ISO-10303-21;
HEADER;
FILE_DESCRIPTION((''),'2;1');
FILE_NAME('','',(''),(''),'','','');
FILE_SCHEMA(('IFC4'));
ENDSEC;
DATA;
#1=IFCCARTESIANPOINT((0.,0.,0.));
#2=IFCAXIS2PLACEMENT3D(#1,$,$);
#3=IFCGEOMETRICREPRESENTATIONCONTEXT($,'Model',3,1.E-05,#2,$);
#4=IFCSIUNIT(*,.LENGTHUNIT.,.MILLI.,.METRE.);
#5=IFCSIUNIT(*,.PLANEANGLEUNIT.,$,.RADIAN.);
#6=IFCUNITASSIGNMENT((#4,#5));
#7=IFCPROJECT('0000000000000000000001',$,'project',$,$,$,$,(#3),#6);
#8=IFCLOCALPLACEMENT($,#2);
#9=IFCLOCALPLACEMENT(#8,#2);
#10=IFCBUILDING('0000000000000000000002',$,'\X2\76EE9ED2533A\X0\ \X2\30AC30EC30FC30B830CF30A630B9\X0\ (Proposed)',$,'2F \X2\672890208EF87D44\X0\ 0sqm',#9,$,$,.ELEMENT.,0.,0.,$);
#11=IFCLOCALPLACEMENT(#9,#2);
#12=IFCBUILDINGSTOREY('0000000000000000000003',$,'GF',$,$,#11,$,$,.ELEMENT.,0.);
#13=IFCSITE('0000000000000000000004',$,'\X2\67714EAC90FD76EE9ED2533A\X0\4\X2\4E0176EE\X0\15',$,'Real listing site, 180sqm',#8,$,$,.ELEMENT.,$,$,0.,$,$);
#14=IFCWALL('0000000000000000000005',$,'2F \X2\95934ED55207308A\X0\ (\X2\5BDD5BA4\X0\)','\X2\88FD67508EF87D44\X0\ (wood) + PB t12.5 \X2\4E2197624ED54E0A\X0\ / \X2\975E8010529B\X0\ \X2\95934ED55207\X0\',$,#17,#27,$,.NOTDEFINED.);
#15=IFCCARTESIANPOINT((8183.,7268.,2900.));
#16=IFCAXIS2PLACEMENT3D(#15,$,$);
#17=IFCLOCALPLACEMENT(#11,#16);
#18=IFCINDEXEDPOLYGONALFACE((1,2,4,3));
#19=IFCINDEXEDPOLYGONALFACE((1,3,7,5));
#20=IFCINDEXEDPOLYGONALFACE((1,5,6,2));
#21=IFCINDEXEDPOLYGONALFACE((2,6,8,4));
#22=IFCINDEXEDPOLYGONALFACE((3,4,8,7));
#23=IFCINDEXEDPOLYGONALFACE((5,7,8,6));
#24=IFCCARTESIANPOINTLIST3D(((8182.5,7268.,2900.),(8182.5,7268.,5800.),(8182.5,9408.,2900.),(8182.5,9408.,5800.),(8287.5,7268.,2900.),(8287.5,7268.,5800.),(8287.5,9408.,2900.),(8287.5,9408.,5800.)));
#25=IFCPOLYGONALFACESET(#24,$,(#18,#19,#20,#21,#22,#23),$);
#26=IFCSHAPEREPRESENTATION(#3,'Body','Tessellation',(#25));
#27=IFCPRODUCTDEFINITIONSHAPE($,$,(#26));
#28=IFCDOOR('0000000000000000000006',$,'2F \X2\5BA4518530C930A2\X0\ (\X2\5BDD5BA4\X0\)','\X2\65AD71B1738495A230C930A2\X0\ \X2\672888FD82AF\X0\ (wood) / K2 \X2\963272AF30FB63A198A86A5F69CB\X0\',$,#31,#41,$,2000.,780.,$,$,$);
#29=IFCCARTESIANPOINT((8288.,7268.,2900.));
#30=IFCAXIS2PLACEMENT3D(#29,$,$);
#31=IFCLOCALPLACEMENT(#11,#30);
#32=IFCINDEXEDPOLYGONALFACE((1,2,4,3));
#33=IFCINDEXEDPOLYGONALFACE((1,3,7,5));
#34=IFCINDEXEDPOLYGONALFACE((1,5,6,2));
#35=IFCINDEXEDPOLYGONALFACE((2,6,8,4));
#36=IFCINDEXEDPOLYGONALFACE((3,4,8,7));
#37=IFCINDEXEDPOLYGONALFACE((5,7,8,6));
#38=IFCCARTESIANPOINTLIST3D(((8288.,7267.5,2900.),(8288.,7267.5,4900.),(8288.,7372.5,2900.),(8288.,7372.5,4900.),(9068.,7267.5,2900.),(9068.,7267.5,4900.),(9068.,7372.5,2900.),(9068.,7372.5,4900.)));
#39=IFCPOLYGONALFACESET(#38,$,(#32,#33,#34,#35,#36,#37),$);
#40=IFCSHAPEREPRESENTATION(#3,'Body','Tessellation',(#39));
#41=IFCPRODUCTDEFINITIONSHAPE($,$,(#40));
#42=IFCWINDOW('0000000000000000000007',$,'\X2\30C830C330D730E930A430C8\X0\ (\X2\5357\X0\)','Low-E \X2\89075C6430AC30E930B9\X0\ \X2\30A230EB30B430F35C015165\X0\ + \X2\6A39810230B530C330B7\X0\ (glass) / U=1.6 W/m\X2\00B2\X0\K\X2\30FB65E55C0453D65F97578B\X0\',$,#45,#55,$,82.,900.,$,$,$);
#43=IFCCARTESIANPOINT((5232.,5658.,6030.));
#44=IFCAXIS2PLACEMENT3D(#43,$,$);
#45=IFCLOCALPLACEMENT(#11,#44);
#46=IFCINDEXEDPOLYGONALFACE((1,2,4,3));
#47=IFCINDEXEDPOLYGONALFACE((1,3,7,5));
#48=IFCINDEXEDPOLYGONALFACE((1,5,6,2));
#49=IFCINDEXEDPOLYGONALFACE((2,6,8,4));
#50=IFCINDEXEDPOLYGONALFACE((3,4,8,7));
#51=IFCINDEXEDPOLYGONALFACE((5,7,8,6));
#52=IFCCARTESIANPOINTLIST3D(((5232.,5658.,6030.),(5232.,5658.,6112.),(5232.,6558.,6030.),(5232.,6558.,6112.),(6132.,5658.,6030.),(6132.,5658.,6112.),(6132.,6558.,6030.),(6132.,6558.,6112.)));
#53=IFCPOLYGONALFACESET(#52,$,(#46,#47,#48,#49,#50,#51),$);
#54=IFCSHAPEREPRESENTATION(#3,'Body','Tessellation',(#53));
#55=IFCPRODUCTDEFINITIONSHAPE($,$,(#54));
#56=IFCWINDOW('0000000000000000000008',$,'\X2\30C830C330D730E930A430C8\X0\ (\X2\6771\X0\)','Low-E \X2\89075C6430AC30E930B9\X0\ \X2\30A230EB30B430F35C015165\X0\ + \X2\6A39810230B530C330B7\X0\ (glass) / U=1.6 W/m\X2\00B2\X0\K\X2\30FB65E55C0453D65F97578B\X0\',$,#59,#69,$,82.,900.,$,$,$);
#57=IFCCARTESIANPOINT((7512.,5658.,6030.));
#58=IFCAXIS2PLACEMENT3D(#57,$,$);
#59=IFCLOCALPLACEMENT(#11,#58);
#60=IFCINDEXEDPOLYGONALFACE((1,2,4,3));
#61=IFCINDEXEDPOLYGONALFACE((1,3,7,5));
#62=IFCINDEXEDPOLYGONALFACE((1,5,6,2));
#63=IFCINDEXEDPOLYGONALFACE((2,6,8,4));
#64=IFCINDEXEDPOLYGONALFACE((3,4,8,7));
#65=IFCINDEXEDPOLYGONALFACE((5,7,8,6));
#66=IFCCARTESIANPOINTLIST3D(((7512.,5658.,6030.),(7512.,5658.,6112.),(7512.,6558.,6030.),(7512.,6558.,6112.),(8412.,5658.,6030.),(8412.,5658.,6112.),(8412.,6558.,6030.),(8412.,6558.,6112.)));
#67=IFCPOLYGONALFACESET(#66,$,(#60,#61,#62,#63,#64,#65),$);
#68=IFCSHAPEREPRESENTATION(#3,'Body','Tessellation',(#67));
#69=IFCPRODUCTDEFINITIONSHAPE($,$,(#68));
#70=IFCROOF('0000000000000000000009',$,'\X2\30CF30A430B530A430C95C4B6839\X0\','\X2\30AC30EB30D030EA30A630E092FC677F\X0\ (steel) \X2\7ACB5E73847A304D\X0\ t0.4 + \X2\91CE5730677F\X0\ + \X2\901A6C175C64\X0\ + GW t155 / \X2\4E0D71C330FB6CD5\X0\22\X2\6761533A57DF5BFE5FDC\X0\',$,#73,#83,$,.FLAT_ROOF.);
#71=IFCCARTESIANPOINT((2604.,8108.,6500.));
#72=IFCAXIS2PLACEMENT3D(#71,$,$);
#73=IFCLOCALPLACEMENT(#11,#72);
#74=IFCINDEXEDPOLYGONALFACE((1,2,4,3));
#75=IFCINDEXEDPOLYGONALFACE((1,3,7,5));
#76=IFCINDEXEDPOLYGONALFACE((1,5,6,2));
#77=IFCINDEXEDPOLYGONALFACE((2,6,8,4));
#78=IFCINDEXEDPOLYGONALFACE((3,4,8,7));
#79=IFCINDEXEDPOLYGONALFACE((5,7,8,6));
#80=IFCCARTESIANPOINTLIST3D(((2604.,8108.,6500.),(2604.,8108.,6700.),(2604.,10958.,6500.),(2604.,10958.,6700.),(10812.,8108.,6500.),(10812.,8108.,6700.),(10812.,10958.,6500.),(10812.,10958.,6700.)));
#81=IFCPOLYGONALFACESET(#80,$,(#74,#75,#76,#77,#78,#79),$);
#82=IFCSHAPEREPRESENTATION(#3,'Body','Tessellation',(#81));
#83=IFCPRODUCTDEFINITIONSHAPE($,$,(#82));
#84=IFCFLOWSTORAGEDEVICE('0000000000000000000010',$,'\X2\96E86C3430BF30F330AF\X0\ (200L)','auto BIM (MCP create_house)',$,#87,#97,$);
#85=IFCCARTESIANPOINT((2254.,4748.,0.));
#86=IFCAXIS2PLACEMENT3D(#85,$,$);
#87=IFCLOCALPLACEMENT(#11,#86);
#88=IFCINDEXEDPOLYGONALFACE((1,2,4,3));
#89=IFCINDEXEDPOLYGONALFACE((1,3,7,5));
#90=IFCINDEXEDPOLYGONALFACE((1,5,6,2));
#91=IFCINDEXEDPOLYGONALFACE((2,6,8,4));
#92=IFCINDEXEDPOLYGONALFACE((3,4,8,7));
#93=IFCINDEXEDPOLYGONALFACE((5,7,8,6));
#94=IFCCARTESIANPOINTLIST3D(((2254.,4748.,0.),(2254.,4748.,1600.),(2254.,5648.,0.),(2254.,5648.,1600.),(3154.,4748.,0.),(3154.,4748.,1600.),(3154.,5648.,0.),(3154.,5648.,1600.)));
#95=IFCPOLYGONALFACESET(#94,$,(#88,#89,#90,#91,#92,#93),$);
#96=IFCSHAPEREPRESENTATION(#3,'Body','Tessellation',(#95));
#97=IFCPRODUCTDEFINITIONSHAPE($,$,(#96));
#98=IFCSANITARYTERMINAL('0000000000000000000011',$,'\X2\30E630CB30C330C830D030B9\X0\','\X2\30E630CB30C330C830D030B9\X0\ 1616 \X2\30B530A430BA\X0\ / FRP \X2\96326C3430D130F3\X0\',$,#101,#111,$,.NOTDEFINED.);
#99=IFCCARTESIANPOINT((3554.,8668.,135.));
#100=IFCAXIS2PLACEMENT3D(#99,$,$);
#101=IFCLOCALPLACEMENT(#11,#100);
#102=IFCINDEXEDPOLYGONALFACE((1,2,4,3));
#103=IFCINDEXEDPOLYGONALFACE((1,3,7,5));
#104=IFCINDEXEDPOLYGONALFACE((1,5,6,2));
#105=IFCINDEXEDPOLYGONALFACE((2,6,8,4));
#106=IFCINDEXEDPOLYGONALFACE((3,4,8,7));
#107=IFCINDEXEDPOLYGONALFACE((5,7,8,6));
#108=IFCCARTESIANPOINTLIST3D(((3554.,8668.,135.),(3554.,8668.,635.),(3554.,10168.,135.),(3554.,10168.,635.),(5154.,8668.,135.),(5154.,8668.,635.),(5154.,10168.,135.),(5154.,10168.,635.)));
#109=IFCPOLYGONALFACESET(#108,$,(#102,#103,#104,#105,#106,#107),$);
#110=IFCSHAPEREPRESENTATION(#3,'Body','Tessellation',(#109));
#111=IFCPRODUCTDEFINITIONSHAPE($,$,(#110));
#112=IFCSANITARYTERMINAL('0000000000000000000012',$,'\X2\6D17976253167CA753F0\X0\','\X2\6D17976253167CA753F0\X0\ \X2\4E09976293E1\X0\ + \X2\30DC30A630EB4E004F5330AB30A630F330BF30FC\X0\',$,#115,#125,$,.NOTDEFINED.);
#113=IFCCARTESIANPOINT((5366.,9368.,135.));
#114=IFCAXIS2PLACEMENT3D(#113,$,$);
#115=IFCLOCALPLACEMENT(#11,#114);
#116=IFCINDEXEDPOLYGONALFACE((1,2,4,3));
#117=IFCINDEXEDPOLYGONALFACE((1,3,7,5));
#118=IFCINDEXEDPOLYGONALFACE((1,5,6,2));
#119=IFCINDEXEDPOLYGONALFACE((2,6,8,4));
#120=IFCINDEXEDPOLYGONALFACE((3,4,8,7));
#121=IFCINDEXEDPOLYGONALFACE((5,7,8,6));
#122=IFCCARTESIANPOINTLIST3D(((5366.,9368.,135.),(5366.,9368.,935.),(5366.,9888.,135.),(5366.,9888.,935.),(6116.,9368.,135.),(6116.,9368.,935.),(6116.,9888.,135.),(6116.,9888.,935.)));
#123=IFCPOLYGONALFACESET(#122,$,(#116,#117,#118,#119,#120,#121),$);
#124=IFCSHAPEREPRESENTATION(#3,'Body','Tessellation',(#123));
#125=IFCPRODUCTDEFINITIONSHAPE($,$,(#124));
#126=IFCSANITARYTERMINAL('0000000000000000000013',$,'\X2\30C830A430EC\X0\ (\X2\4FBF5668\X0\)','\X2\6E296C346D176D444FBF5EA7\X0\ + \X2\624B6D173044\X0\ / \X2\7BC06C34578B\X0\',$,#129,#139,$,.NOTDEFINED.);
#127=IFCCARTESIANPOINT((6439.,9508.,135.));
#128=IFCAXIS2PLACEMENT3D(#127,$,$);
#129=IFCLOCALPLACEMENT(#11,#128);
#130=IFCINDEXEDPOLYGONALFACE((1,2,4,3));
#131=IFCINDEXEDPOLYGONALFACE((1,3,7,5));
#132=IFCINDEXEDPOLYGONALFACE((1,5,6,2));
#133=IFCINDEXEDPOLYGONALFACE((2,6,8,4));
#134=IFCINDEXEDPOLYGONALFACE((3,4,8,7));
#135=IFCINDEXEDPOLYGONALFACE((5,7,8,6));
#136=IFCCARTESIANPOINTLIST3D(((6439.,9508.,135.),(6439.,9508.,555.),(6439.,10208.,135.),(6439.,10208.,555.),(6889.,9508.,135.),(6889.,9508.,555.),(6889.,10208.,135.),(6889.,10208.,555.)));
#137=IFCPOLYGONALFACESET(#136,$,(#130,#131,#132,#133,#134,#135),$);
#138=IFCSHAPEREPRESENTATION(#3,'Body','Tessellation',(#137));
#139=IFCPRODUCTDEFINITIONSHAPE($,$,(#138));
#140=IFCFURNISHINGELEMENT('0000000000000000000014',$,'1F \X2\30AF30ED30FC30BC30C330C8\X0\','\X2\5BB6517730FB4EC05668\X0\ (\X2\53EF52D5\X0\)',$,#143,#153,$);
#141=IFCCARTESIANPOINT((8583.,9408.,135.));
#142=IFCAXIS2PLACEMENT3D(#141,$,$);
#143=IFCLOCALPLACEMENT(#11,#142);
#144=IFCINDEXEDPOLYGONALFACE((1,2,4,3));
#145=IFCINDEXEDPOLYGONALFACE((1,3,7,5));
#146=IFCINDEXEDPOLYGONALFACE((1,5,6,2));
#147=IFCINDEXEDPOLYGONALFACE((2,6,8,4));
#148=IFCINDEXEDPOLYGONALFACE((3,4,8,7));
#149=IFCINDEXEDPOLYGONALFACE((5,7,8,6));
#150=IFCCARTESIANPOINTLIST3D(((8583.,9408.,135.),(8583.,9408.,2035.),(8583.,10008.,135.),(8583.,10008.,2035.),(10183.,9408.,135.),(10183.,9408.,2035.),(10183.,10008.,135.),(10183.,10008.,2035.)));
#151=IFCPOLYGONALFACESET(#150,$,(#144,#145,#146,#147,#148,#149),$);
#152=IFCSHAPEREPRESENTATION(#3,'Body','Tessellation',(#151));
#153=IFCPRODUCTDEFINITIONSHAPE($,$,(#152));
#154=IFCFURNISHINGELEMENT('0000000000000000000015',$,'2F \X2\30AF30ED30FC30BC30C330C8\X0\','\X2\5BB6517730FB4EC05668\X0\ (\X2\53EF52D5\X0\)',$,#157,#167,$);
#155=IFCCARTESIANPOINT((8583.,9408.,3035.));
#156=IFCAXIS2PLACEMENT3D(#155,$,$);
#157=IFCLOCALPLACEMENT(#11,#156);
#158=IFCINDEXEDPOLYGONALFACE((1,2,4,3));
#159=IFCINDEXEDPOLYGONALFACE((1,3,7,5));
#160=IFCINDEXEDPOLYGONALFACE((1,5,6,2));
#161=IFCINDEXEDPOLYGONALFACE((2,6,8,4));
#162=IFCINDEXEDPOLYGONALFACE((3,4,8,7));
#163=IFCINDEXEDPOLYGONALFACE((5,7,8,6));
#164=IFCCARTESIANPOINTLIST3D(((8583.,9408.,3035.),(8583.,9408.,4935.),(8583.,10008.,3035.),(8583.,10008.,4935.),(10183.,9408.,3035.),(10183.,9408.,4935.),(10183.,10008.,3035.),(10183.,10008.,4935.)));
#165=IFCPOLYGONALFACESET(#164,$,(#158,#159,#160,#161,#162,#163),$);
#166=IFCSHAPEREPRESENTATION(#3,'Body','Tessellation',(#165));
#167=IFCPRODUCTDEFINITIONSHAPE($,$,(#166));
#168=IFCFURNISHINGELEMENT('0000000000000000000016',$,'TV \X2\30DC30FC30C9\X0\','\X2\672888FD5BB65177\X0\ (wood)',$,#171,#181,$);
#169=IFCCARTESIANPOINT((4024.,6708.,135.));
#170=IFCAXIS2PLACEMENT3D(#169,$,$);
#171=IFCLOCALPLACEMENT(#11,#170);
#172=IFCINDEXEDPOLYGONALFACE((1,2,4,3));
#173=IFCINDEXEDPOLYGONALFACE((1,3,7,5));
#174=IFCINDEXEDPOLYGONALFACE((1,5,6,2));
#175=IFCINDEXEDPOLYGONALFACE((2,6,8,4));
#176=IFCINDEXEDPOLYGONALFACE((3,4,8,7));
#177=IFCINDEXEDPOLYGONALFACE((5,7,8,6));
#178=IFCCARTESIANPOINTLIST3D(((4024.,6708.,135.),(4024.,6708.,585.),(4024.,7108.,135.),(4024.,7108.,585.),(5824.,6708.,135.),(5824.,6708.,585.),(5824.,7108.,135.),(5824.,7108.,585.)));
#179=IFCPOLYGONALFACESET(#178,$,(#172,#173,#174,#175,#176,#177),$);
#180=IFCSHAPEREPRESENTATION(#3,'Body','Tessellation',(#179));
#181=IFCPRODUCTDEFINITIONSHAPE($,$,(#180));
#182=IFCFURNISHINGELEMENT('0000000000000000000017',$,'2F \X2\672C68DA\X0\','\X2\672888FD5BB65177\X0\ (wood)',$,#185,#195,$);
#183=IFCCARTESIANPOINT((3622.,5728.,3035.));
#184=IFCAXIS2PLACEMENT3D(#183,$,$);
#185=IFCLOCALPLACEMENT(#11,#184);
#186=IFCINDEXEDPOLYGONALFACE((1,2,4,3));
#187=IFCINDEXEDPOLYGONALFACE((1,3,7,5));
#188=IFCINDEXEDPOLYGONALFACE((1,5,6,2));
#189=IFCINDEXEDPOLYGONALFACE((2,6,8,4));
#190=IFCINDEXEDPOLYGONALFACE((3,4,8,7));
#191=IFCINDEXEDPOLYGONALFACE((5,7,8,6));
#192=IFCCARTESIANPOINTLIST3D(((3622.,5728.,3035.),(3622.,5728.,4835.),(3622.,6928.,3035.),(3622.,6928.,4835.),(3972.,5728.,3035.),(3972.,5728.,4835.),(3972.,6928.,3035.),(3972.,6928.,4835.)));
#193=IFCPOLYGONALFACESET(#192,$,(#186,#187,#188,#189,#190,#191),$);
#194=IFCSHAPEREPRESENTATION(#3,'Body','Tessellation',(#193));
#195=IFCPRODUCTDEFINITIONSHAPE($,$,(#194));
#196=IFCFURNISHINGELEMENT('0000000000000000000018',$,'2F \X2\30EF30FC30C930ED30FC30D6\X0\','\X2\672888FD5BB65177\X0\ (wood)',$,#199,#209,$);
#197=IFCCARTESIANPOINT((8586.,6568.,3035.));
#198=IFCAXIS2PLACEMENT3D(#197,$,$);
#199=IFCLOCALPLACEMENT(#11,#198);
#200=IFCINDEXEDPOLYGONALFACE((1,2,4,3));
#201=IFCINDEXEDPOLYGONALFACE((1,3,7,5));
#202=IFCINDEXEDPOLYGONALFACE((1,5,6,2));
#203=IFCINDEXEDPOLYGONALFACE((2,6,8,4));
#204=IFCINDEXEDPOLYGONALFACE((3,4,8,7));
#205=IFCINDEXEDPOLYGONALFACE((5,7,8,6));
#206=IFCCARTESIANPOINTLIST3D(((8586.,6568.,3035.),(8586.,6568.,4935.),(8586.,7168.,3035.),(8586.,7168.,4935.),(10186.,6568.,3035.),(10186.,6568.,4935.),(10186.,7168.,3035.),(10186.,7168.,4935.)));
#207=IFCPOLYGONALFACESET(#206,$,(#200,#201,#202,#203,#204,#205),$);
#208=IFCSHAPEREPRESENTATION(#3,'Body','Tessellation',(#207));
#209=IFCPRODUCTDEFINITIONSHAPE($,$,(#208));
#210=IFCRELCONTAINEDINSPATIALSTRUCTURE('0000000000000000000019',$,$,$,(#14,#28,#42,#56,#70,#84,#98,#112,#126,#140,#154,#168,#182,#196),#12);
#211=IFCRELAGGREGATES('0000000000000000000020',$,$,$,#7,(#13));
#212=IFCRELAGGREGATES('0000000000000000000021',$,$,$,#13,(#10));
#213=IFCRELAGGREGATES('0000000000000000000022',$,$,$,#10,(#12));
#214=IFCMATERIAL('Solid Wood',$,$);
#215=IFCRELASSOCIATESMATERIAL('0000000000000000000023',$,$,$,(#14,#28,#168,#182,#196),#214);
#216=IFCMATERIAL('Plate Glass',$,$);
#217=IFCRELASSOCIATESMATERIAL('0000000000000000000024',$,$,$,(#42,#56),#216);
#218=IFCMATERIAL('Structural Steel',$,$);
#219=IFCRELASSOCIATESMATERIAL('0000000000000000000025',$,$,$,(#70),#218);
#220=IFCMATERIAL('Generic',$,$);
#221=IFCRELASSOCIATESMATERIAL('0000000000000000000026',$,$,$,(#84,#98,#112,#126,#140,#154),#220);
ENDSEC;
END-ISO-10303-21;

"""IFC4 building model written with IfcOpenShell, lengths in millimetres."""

from ifc_helpers import new_model, si_unit, frame, frame_2d, origin, place, context, project, spatial, rectangle, extrude, material, element, save


model = new_model("IFC4")

# Units and contexts
model_context = context("Model", 3, precision=1e-05, world=origin())
ifc_project = project(units=[si_unit("LENGTHUNIT", "METRE", prefix="MILLI"), si_unit("PLANEANGLEUNIT", "RADIAN")], contexts=[model_context])

# Site, building, storey
site_placement = place(None, origin())
site = spatial("IfcSite", under=ifc_project, at=site_placement, Name="東京都目黒区4丁目15", ObjectType="Real listing site, 180sqm", CompositionType="ELEMENT", RefElevation=0.0)
building_placement = place(site_placement, origin())
building = spatial("IfcBuilding", under=site, at=building_placement, Name="目黒区 ガレージハウス (Proposed)", ObjectType="2F 木造軸組 0sqm", CompositionType="ELEMENT", ElevationOfRefHeight=0.0, ElevationOfTerrain=0.0)
storey_placement = place(building_placement, origin())
storey = spatial("IfcBuildingStorey", under=building, at=storey_placement, Name="GF", CompositionType="ELEMENT", Elevation=0.0)

# Shared definitions
ifc_material_1 = material(Name="Solid Wood")
ifc_material_2 = material(Name="Plate Glass")

# Wall
wall_1_placement = place(storey_placement, frame((8183.0, 7268.0, 2900.0)))
element("IfcWall", 1, at=wall_1_placement, inside=storey, material=ifc_material_1, Name="2F 間仕切り (寝室)", Description="製材軸組 (wood) + PB t12.5 両面仕上 / 非耐力 間仕切", PredefinedType="NOTDEFINED", context=model_context, shape_type="SweptSolid", body=[
    extrude(rectangle(XDim=105.0, YDim=2140.0, at=frame_2d((52.0, 1070.0))), frame((8183.0, 7268.0, 2900.0)), (0.0, 0.0, 1.0), 2900.0),
])

# Door
door_1_placement = place(storey_placement, frame((8288.0, 7268.0, 2900.0)))
element("IfcDoor", 2, at=door_1_placement, inside=storey, material=ifc_material_1, Name="2F 室内ドア (寝室)", Description="断熱玄関ドア 木製芯 (wood) / K2 防犯・採風機構", OverallHeight=2000.0, OverallWidth=780.0, context=model_context, shape_type="SweptSolid", body=[
    extrude(rectangle(XDim=780.0, YDim=105.0, at=frame_2d((390.0, 52.0))), frame((8288.0, 7268.0, 2900.0)), (0.0, 0.0, 1.0), 2000.0),
])

# Windows
window_1_placement = place(storey_placement, frame((5232.0, 5658.0, 6030.0)))
element("IfcWindow", 3, at=window_1_placement, inside=storey, material=ifc_material_2, Name="トップライト (南)", Description="Low-E 複層ガラス アルゴン封入 + 樹脂サッシ (glass) / U=1.6 W/m²K・日射取得型", OverallHeight=82.0, OverallWidth=900.0, context=model_context, shape_type="SweptSolid", body=[
    extrude(rectangle(XDim=900.0, YDim=900.0, at=frame_2d((450.0, 450.0))), frame((5232.0, 5658.0, 6030.0)), (0.0, 0.0, 1.0), 82.0),
])
window_2_placement = place(storey_placement, frame((7512.0, 5658.0, 6030.0)))
element("IfcWindow", 4, at=window_2_placement, inside=storey, material=ifc_material_2, Name="トップライト (東)", Description="Low-E 複層ガラス アルゴン封入 + 樹脂サッシ (glass) / U=1.6 W/m²K・日射取得型", OverallHeight=82.0, OverallWidth=900.0, context=model_context, shape_type="SweptSolid", body=[
    extrude(rectangle(XDim=900.0, YDim=900.0, at=frame_2d((450.0, 450.0))), frame((7512.0, 5658.0, 6030.0)), (0.0, 0.0, 1.0), 82.0),
])

# Roof
ifc_material_3 = material(Name="Structural Steel")
roof_placement = place(storey_placement, frame((2604.0, 8108.0, 6500.0)))
element("IfcRoof", 5, at=roof_placement, inside=storey, material=ifc_material_3, Name="ハイサイド屋根", Description="ガルバリウム鋼板 (steel) 立平葺き t0.4 + 野地板 + 通気層 + GW t155 / 不燃・法22条区域対応", PredefinedType="FLAT_ROOF", context=model_context, shape_type="SweptSolid", body=[
    extrude(rectangle(XDim=8208.0, YDim=2850.0, at=frame_2d((4104.0, 1425.0))), frame((2604.0, 8108.0, 6500.0)), (0.0, 0.0, 1.0), 200.0),
])

# Flow storage device
ifc_material_4 = material(Name="Generic")
flow_storage_device_placement = place(storey_placement, frame((2254.0, 4748.0, 0.0)))
element("IfcFlowStorageDevice", 6, at=flow_storage_device_placement, inside=storey, material=ifc_material_4, Name="雨水タンク (200L)", Description="auto BIM (MCP create_house)", context=model_context, shape_type="SweptSolid", body=[
    extrude(rectangle(XDim=900.0, YDim=900.0, at=frame_2d((450.0, 450.0))), frame((2254.0, 4748.0, 0.0)), (0.0, 0.0, 1.0), 1600.0),
])

# Sanitary terminals
sanitary_terminal_1_placement = place(storey_placement, frame((3554.0, 8668.0, 135.0)))
element("IfcSanitaryTerminal", 7, at=sanitary_terminal_1_placement, inside=storey, material=ifc_material_4, Name="ユニットバス", Description="ユニットバス 1616 サイズ / FRP 防水パン", PredefinedType="NOTDEFINED", context=model_context, shape_type="SweptSolid", body=[
    extrude(rectangle(XDim=1600.0, YDim=1500.0, at=frame_2d((800.0, 750.0))), frame((3554.0, 8668.0, 135.0)), (0.0, 0.0, 1.0), 500.0),
])
sanitary_terminal_2_placement = place(storey_placement, frame((5366.0, 9368.0, 135.0)))
element("IfcSanitaryTerminal", 8, at=sanitary_terminal_2_placement, inside=storey, material=ifc_material_4, Name="洗面化粧台", Description="洗面化粧台 三面鏡 + ボウル一体カウンター", PredefinedType="NOTDEFINED", context=model_context, shape_type="SweptSolid", body=[
    extrude(rectangle(XDim=750.0, YDim=520.0, at=frame_2d((375.0, 260.0))), frame((5366.0, 9368.0, 135.0)), (0.0, 0.0, 1.0), 800.0),
])
sanitary_terminal_3_placement = place(storey_placement, frame((6439.0, 9508.0, 135.0)))
element("IfcSanitaryTerminal", 9, at=sanitary_terminal_3_placement, inside=storey, material=ifc_material_4, Name="トイレ (便器)", Description="温水洗浄便座 + 手洗い / 節水型", PredefinedType="NOTDEFINED", context=model_context, shape_type="SweptSolid", body=[
    extrude(rectangle(XDim=450.0, YDim=700.0, at=frame_2d((225.0, 350.0))), frame((6439.0, 9508.0, 135.0)), (0.0, 0.0, 1.0), 420.0),
])

# Furnishing elements
furnishing_1_placement = place(storey_placement, frame((8583.0, 9408.0, 135.0)))
element("IfcFurnishingElement", 10, at=furnishing_1_placement, inside=storey, material=ifc_material_4, Name="1F クローゼット", Description="家具・什器 (可動)", context=model_context, shape_type="SweptSolid", body=[
    extrude(rectangle(XDim=1600.0, YDim=600.0, at=frame_2d((800.0, 300.0))), frame((8583.0, 9408.0, 135.0)), (0.0, 0.0, 1.0), 1900.0),
])
furnishing_2_placement = place(storey_placement, frame((8583.0, 9408.0, 3035.0)))
element("IfcFurnishingElement", 11, at=furnishing_2_placement, inside=storey, material=ifc_material_4, Name="2F クローゼット", Description="家具・什器 (可動)", context=model_context, shape_type="SweptSolid", body=[
    extrude(rectangle(XDim=1600.0, YDim=600.0, at=frame_2d((800.0, 300.0))), frame((8583.0, 9408.0, 3035.0)), (0.0, 0.0, 1.0), 1900.0),
])
furnishing_3_placement = place(storey_placement, frame((4024.0, 6708.0, 135.0)))
element("IfcFurnishingElement", 12, at=furnishing_3_placement, inside=storey, material=ifc_material_1, Name="TV ボード", Description="木製家具 (wood)", context=model_context, shape_type="SweptSolid", body=[
    extrude(rectangle(XDim=1800.0, YDim=400.0, at=frame_2d((900.0, 200.0))), frame((4024.0, 6708.0, 135.0)), (0.0, 0.0, 1.0), 450.0),
])
furnishing_4_placement = place(storey_placement, frame((3622.0, 5728.0, 3035.0)))
element("IfcFurnishingElement", 13, at=furnishing_4_placement, inside=storey, material=ifc_material_1, Name="2F 本棚", Description="木製家具 (wood)", context=model_context, shape_type="SweptSolid", body=[
    extrude(rectangle(XDim=350.0, YDim=1200.0, at=frame_2d((175.0, 600.0))), frame((3622.0, 5728.0, 3035.0)), (0.0, 0.0, 1.0), 1800.0),
])
furnishing_5_placement = place(storey_placement, frame((8586.0, 6568.0, 3035.0)))
element("IfcFurnishingElement", 14, at=furnishing_5_placement, inside=storey, material=ifc_material_1, Name="2F ワードローブ", Description="木製家具 (wood)", context=model_context, shape_type="SweptSolid", body=[
    extrude(rectangle(XDim=1600.0, YDim=600.0, at=frame_2d((800.0, 300.0))), frame((8586.0, 6568.0, 3035.0)), (0.0, 0.0, 1.0), 1900.0),
])

save(model, "model.ifc")
